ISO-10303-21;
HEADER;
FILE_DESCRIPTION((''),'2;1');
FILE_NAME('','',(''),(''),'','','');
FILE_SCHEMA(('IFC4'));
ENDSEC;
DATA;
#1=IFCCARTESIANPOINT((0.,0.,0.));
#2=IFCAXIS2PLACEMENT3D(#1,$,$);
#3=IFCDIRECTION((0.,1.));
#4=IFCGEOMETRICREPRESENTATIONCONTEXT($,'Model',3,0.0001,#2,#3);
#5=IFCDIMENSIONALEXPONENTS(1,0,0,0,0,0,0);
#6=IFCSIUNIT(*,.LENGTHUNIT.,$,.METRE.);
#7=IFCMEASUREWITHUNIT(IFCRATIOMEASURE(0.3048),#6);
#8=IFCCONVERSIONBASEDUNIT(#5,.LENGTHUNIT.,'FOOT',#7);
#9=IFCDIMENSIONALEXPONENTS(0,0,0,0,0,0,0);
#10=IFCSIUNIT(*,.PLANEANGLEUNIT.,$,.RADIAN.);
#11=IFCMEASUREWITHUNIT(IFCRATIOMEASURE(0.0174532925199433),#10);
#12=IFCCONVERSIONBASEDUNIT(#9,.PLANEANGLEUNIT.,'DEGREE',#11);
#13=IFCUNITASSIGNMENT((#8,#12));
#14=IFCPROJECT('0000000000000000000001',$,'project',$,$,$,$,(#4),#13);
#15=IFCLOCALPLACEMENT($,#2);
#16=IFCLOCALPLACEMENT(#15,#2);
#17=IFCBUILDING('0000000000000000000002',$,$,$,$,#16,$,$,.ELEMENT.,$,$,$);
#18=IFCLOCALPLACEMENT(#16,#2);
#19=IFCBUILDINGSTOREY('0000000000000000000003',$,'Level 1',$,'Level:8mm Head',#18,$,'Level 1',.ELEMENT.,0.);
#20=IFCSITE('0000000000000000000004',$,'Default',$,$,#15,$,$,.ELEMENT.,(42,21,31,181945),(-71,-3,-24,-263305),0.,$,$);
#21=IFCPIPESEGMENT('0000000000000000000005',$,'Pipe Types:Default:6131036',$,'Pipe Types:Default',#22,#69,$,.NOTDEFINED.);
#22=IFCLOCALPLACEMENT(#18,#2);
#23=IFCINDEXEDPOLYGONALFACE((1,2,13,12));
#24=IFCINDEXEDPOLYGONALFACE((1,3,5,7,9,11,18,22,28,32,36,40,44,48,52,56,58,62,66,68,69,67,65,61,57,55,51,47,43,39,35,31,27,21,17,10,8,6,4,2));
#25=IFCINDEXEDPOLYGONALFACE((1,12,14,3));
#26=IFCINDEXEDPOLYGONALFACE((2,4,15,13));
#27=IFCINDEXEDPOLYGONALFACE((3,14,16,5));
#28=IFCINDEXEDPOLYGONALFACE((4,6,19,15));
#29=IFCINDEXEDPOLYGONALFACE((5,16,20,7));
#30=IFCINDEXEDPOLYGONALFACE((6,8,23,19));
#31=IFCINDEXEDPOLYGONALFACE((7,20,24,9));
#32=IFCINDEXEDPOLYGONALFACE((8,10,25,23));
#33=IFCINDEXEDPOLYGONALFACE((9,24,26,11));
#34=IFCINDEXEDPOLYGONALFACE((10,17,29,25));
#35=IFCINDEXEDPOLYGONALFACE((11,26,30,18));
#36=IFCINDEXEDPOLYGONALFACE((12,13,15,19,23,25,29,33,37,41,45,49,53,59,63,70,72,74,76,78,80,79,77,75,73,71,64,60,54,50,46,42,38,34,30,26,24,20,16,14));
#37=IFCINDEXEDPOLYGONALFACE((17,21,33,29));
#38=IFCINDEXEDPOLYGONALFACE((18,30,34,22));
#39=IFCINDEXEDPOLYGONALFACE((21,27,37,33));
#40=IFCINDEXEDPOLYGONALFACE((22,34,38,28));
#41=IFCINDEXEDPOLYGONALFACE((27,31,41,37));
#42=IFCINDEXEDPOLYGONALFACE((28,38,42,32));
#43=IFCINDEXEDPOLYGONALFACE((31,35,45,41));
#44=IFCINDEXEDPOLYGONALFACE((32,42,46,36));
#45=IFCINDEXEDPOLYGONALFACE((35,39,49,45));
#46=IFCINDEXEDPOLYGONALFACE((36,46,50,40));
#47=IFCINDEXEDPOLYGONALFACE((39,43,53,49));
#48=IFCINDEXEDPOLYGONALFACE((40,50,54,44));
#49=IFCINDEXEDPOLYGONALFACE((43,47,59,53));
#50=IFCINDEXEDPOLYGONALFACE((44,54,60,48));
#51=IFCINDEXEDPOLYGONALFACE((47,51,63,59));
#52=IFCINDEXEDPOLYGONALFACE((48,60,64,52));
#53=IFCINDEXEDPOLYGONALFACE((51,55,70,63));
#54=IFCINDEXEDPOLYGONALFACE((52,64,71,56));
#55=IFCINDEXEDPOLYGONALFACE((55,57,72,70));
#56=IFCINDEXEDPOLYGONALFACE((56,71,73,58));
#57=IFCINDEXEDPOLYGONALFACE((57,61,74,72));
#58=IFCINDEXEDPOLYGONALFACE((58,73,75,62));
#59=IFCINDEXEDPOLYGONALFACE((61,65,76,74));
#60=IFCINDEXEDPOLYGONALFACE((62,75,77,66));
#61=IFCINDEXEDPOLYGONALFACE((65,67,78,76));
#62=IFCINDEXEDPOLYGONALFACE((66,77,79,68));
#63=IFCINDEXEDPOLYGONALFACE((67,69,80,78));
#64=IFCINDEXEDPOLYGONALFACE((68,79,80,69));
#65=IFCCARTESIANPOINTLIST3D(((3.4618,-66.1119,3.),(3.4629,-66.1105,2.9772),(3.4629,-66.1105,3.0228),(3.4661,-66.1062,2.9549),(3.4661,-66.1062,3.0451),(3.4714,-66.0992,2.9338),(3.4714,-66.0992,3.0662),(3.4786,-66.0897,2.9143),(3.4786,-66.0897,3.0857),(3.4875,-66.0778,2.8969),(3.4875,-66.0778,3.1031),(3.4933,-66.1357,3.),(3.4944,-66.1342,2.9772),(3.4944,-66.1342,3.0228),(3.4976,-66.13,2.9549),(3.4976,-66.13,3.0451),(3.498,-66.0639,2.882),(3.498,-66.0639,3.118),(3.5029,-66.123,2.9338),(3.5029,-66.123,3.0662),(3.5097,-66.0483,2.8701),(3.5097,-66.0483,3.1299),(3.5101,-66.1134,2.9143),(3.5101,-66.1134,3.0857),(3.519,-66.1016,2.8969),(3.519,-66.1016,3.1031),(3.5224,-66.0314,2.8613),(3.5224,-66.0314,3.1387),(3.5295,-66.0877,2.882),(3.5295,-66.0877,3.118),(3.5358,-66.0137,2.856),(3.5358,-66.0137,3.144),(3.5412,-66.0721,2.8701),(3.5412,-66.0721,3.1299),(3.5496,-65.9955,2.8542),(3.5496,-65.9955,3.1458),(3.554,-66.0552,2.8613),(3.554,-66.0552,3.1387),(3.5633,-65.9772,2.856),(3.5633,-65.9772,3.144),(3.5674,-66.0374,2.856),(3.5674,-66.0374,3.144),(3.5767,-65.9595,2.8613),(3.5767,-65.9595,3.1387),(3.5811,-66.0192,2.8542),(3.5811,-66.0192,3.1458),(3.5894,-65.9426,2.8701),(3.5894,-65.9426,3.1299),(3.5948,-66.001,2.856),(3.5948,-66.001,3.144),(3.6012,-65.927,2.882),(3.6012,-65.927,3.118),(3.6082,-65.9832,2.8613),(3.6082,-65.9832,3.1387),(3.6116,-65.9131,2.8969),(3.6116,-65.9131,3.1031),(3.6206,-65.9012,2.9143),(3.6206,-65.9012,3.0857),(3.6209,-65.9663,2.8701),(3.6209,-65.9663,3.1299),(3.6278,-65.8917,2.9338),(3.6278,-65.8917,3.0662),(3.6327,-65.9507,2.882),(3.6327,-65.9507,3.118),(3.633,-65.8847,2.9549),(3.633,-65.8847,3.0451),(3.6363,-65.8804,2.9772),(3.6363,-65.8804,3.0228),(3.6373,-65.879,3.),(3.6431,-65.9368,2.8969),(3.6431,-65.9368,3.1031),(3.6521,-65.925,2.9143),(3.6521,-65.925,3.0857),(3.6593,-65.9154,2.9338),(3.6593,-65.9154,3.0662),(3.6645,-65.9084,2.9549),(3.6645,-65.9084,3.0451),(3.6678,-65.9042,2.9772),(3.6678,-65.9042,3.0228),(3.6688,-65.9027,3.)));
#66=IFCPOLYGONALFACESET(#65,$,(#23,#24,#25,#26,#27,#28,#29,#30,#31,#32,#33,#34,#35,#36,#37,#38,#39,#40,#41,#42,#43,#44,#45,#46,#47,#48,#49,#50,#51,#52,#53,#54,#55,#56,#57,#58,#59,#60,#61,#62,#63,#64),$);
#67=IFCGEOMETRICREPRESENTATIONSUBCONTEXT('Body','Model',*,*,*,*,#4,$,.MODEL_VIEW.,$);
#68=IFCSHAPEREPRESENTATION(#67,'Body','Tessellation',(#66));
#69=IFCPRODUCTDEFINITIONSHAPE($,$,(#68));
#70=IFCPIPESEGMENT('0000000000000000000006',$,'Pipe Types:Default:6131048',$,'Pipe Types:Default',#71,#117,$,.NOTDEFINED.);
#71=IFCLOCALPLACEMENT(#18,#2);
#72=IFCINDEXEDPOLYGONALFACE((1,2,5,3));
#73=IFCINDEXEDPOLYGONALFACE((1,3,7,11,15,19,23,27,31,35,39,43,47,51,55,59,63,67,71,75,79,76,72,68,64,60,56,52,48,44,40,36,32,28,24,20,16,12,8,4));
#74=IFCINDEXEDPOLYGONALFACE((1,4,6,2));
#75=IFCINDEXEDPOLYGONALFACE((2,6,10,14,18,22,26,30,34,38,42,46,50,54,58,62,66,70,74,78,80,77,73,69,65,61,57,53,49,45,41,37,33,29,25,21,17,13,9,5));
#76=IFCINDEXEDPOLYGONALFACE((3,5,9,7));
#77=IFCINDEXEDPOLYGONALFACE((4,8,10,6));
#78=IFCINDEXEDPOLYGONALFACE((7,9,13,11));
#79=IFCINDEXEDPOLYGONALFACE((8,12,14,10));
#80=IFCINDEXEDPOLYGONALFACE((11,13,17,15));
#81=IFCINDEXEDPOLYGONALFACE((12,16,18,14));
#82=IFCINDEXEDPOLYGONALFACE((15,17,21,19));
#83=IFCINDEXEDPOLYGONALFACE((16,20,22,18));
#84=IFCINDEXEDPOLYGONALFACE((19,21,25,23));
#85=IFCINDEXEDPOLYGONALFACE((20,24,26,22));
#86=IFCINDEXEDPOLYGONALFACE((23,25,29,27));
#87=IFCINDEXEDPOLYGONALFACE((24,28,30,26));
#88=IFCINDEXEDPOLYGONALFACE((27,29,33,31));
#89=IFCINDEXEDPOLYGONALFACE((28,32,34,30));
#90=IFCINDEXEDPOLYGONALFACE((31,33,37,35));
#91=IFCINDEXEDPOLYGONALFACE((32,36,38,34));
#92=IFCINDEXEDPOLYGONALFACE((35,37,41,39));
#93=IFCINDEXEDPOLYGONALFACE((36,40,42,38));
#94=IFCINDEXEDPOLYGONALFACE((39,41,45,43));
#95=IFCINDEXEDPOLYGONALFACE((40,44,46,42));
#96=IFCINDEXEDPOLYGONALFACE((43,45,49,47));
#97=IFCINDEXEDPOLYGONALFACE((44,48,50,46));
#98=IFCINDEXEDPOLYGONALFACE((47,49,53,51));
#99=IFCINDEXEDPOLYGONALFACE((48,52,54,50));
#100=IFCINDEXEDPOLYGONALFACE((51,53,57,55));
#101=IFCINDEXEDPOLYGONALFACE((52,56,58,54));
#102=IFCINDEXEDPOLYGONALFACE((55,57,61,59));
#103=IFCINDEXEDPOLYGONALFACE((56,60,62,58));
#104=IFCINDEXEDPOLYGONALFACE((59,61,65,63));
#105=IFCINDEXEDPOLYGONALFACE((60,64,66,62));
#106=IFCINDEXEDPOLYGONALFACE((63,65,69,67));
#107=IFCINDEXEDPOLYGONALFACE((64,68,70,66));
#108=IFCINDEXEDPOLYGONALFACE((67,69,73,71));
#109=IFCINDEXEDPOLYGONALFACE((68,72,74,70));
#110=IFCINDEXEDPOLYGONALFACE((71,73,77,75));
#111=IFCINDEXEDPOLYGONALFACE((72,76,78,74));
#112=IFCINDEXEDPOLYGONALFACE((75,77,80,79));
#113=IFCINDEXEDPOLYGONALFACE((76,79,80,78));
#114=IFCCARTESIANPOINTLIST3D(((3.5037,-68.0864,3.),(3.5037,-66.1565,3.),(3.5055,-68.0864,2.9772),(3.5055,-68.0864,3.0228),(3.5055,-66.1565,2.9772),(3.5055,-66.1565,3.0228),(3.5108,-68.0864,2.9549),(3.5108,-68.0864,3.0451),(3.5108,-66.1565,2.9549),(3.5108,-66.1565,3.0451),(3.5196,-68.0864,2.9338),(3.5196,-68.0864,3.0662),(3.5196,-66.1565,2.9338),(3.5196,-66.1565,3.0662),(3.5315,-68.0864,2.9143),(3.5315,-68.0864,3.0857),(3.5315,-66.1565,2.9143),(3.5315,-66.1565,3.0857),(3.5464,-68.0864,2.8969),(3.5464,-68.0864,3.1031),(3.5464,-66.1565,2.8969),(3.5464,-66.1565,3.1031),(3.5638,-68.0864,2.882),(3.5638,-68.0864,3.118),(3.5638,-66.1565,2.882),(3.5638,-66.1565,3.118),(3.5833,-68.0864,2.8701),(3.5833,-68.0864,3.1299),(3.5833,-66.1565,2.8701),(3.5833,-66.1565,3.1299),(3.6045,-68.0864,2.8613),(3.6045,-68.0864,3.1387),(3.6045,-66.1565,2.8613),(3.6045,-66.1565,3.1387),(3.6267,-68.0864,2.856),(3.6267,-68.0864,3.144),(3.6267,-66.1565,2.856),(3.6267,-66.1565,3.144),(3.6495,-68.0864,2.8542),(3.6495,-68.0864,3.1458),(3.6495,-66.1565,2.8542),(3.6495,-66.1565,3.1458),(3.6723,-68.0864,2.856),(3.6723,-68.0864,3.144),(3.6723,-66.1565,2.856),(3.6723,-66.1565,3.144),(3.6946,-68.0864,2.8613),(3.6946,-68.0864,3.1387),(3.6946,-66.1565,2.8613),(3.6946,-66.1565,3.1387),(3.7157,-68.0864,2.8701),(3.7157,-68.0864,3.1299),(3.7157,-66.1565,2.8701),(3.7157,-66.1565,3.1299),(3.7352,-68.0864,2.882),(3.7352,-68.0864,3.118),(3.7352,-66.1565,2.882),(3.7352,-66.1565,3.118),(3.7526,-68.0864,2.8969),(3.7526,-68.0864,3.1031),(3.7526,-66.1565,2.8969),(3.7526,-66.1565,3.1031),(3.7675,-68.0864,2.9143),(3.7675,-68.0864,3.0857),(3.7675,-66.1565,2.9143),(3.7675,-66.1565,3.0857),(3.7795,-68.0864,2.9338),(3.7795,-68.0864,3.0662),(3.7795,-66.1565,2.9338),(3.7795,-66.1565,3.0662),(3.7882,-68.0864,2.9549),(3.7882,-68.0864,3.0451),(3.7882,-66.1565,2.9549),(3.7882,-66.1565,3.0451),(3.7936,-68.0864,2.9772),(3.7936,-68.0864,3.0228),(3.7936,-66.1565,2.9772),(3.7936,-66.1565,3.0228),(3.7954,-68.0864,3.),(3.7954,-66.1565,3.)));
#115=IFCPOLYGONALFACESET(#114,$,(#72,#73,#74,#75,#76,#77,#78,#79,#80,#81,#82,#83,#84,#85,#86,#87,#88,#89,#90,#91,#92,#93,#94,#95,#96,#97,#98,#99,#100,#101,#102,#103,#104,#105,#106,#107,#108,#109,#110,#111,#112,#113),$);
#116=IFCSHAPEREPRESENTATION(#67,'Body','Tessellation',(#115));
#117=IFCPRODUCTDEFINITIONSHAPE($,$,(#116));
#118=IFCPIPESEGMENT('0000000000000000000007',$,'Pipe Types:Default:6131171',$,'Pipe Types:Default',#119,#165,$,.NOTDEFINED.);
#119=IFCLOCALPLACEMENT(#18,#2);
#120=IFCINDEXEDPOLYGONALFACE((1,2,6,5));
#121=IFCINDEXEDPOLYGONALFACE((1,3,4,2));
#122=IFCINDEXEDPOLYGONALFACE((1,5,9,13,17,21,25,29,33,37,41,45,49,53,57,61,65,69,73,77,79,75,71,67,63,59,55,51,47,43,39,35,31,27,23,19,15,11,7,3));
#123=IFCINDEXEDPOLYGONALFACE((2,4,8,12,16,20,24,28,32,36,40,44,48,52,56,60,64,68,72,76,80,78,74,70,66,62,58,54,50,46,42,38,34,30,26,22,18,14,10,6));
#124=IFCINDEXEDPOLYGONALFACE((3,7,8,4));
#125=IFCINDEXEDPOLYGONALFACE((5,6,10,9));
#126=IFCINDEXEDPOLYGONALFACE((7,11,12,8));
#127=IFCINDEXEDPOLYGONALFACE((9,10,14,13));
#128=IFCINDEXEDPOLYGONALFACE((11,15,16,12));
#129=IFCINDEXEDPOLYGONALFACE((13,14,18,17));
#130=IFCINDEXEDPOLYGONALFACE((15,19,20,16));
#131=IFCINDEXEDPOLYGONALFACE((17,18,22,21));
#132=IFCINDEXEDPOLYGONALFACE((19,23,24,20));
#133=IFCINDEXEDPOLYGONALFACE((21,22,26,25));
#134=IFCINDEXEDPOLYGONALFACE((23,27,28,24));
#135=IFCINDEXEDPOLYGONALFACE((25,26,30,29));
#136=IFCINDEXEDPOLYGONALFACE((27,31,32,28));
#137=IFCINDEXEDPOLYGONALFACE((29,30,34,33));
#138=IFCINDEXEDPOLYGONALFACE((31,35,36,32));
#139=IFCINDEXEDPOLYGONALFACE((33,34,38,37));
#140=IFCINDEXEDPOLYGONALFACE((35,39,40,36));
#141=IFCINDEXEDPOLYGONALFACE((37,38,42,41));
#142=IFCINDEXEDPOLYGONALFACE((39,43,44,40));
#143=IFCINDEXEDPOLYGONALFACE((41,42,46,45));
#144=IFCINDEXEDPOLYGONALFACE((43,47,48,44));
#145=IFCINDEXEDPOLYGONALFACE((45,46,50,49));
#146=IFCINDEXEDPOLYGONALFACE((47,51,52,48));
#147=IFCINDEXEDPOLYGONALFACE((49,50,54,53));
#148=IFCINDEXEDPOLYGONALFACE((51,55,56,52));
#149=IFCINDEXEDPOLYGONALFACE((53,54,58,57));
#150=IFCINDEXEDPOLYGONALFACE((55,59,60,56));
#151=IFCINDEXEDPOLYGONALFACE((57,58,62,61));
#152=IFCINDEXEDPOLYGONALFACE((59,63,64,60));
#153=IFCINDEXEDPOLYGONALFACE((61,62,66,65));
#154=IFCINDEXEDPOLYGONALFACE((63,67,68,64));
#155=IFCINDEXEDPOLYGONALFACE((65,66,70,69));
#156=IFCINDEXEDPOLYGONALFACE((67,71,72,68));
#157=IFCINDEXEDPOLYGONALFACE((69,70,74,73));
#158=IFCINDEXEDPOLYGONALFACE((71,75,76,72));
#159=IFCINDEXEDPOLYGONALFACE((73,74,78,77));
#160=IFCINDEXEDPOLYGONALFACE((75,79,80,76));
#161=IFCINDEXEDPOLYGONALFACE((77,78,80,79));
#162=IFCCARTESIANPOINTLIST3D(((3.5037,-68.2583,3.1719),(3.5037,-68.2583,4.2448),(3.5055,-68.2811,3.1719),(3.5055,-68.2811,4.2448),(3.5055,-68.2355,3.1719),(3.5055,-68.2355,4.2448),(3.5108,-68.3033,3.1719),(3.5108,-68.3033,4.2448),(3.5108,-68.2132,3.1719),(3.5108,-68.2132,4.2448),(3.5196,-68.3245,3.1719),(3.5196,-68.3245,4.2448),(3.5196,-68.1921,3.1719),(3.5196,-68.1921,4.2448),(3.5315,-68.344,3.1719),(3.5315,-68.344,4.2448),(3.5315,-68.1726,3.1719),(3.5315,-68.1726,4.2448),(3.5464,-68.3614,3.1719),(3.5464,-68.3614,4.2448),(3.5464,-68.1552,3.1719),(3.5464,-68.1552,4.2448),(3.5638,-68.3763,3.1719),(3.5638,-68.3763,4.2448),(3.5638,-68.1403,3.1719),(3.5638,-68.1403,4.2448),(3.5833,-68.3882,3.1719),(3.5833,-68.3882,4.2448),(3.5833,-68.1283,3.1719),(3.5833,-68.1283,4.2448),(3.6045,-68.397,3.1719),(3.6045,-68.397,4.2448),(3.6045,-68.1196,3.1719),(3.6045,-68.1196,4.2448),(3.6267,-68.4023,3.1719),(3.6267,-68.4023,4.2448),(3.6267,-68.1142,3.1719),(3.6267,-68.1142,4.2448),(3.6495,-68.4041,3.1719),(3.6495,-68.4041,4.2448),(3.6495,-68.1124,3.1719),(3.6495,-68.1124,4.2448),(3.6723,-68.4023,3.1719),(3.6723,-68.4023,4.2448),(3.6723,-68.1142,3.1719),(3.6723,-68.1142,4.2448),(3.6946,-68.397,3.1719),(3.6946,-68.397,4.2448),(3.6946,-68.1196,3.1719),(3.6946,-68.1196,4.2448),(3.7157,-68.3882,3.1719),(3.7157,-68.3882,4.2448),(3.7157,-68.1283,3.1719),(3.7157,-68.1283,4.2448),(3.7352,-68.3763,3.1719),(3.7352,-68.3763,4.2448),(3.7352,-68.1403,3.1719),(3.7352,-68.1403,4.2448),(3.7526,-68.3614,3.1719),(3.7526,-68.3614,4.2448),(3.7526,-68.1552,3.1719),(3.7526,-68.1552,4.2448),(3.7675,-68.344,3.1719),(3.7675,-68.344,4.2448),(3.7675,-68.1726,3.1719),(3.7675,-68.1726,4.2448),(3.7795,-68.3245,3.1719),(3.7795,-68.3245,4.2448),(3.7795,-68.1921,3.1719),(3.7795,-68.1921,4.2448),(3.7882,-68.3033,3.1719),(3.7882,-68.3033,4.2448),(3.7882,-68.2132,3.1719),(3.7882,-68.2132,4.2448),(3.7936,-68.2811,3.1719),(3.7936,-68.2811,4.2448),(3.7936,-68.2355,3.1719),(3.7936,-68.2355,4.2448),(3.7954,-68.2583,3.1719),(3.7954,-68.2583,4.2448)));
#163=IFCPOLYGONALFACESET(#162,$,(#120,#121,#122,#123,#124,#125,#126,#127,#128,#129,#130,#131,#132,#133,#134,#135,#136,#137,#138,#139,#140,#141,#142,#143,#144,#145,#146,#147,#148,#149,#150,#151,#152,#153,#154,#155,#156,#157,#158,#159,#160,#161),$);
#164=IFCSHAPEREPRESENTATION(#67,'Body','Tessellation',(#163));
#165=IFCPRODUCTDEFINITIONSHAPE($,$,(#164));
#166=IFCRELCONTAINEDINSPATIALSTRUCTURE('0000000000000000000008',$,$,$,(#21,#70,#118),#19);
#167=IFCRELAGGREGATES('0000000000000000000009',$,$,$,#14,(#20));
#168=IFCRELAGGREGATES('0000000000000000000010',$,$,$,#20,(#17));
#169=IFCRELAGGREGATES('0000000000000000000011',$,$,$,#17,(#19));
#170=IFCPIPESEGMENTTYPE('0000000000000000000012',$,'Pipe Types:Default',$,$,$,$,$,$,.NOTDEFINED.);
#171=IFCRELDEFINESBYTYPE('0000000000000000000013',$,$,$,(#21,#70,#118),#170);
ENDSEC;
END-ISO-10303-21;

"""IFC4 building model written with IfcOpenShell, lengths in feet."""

from ifc_helpers import new_model, entity, si_unit, converted_unit, direction, frame, origin, place, context, subcontext, project, spatial, indexed_curve, outline, extrude, type_object, element, save


model = new_model("IFC4")

# Units and contexts
model_context = context("Model", 3, precision=0.0001, world=origin(), true_north=direction((0.0, 1.0)))
body_context = subcontext(model_context, "Body", "Model", "MODEL_VIEW")
ifc_project = project(units=[converted_unit("LENGTHUNIT", "FOOT", entity("IfcRatioMeasure", 0.3048), si_unit("LENGTHUNIT", "METRE"), dimensions=[1, 0, 0, 0, 0, 0, 0]), converted_unit("PLANEANGLEUNIT", "DEGREE", entity("IfcRatioMeasure", 0.0174532925199433), si_unit("PLANEANGLEUNIT", "RADIAN"), dimensions=[0, 0, 0, 0, 0, 0, 0])], contexts=[model_context])

# Site, building, storey
site_placement = place(None, origin())
site = spatial("IfcSite", under=ifc_project, at=site_placement, Name="Default", CompositionType="ELEMENT", RefLatitude=(42, 21, 31, 181945), RefLongitude=(-71, -3, -24, -263305), RefElevation=0.0)
building_placement = place(site_placement, origin())
building = spatial("IfcBuilding", under=site, at=building_placement, CompositionType="ELEMENT")
storey_placement = place(building_placement, origin())
storey = spatial("IfcBuildingStorey", under=building, at=storey_placement, Name="Level 1", ObjectType="Level:8mm Head", LongName="Level 1", CompositionType="ELEMENT", Elevation=0.0)

# Pipe segments
pipe_segment_type = type_object("IfcPipeSegmentType", Name="Pipe Types:Default", PredefinedType="NOTDEFINED")
pipe_segment_1_placement = place(storey_placement, origin())
element("IfcPipeSegment", 1, at=pipe_segment_1_placement, inside=storey, type_object=pipe_segment_type, Name="Pipe Types:Default:6131036", ObjectType="Pipe Types:Default", PredefinedType="NOTDEFINED", context=body_context, shape_type="SweptSolid", body=[
    extrude(outline(indexed_curve([(0.1458, 0.0), (0.144, 0.0228), (0.1387, 0.0451), (0.1299, 0.0662), (0.118, 0.0857), (0.1031, 0.1031), (0.0857, 0.118), (0.0662, 0.1299), (0.0451, 0.1387), (0.0228, 0.144), (0.0, 0.1458), (-0.0228, 0.144), (-0.0451, 0.1387), (-0.0662, 0.1299), (-0.0857, 0.118), (-0.1031, 0.1031), (-0.118, 0.0857), (-0.1299, 0.0662), (-0.1387, 0.0451), (-0.144, 0.0228), (-0.1458, 0.0), (-0.144, -0.0228), (-0.1387, -0.0451), (-0.1299, -0.0662), (-0.118, -0.0857), (-0.1031, -0.1031), (-0.0857, -0.118), (-0.0662, -0.1299), (-0.0451, -0.1387), (-0.0228, -0.144), (0.0, -0.1458), (0.0228, -0.144), (0.0451, -0.1387), (0.0662, -0.1299), (0.0857, -0.118), (0.1031, -0.1031), (0.118, -0.0857), (0.1299, -0.0662), (0.1387, -0.0451), (0.144, -0.0228), (0.1458, 0.0)], self_intersect=False)), frame((3.5811, -66.0192, 3.0), z_axis=(-0.798636, 0.601815, 0.0), x_axis=(-0.601815, -0.798636, 0.0)), (0.0, 0.0, 1.0), 0.0395),
])
pipe_segment_2_placement = place(storey_placement, origin())
element("IfcPipeSegment", 2, at=pipe_segment_2_placement, inside=storey, type_object=pipe_segment_type, Name="Pipe Types:Default:6131048", ObjectType="Pipe Types:Default", PredefinedType="NOTDEFINED", context=body_context, shape_type="SweptSolid", body=[
    extrude(outline(indexed_curve([(0.1458, 0.0), (0.144, 0.0228), (0.1387, 0.0451), (0.1299, 0.0662), (0.118, 0.0857), (0.1031, 0.1031), (0.0857, 0.118), (0.0662, 0.1299), (0.0451, 0.1387), (0.0228, 0.144), (0.0, 0.1458), (-0.0228, 0.144), (-0.0451, 0.1387), (-0.0662, 0.1299), (-0.0857, 0.118), (-0.1031, 0.1031), (-0.118, 0.0857), (-0.1299, 0.0662), (-0.1387, 0.0451), (-0.144, 0.0228), (-0.1458, 0.0), (-0.144, -0.0228), (-0.1387, -0.0451), (-0.1299, -0.0662), (-0.118, -0.0857), (-0.1031, -0.1031), (-0.0857, -0.118), (-0.0662, -0.1299), (-0.0451, -0.1387), (-0.0228, -0.144), (0.0, -0.1458), (0.0228, -0.144), (0.0451, -0.1387), (0.0662, -0.1299), (0.0857, -0.118), (0.1031, -0.1031), (0.118, -0.0857), (0.1299, -0.0662), (0.1387, -0.0451), (0.144, -0.0228), (0.1458, 0.0)], self_intersect=False)), frame((3.6495, -68.0864, 3.0), z_axis=(0.0, 1.0, 0.0), x_axis=(-1.0, 0.0, 0.0)), (0.0, 0.0, 1.0), 1.9299),
])
pipe_segment_3_placement = place(storey_placement, origin())
element("IfcPipeSegment", 3, at=pipe_segment_3_placement, inside=storey, type_object=pipe_segment_type, Name="Pipe Types:Default:6131171", ObjectType="Pipe Types:Default", PredefinedType="NOTDEFINED", context=body_context, shape_type="SweptSolid", body=[
    extrude(outline(indexed_curve([(0.1458, 0.0), (0.144, 0.0228), (0.1387, 0.0451), (0.1299, 0.0662), (0.118, 0.0857), (0.1031, 0.1031), (0.0857, 0.118), (0.0662, 0.1299), (0.0451, 0.1387), (0.0228, 0.144), (0.0, 0.1458), (-0.0228, 0.144), (-0.0451, 0.1387), (-0.0662, 0.1299), (-0.0857, 0.118), (-0.1031, 0.1031), (-0.118, 0.0857), (-0.1299, 0.0662), (-0.1387, 0.0451), (-0.144, 0.0228), (-0.1458, 0.0), (-0.144, -0.0228), (-0.1387, -0.0451), (-0.1299, -0.0662), (-0.118, -0.0857), (-0.1031, -0.1031), (-0.0857, -0.118), (-0.0662, -0.1299), (-0.0451, -0.1387), (-0.0228, -0.144), (0.0, -0.1458), (0.0228, -0.144), (0.0451, -0.1387), (0.0662, -0.1299), (0.0857, -0.118), (0.1031, -0.1031), (0.118, -0.0857), (0.1299, -0.0662), (0.1387, -0.0451), (0.144, -0.0228), (0.1458, 0.0)], self_intersect=False)), frame((3.6495, -68.2583, 3.1719), z_axis=(0.0, 0.0, 1.0), x_axis=(-1.0, 0.0, 0.0)), (0.0, 0.0, 1.0), 1.0729),
])

save(model, "model.ifc")
